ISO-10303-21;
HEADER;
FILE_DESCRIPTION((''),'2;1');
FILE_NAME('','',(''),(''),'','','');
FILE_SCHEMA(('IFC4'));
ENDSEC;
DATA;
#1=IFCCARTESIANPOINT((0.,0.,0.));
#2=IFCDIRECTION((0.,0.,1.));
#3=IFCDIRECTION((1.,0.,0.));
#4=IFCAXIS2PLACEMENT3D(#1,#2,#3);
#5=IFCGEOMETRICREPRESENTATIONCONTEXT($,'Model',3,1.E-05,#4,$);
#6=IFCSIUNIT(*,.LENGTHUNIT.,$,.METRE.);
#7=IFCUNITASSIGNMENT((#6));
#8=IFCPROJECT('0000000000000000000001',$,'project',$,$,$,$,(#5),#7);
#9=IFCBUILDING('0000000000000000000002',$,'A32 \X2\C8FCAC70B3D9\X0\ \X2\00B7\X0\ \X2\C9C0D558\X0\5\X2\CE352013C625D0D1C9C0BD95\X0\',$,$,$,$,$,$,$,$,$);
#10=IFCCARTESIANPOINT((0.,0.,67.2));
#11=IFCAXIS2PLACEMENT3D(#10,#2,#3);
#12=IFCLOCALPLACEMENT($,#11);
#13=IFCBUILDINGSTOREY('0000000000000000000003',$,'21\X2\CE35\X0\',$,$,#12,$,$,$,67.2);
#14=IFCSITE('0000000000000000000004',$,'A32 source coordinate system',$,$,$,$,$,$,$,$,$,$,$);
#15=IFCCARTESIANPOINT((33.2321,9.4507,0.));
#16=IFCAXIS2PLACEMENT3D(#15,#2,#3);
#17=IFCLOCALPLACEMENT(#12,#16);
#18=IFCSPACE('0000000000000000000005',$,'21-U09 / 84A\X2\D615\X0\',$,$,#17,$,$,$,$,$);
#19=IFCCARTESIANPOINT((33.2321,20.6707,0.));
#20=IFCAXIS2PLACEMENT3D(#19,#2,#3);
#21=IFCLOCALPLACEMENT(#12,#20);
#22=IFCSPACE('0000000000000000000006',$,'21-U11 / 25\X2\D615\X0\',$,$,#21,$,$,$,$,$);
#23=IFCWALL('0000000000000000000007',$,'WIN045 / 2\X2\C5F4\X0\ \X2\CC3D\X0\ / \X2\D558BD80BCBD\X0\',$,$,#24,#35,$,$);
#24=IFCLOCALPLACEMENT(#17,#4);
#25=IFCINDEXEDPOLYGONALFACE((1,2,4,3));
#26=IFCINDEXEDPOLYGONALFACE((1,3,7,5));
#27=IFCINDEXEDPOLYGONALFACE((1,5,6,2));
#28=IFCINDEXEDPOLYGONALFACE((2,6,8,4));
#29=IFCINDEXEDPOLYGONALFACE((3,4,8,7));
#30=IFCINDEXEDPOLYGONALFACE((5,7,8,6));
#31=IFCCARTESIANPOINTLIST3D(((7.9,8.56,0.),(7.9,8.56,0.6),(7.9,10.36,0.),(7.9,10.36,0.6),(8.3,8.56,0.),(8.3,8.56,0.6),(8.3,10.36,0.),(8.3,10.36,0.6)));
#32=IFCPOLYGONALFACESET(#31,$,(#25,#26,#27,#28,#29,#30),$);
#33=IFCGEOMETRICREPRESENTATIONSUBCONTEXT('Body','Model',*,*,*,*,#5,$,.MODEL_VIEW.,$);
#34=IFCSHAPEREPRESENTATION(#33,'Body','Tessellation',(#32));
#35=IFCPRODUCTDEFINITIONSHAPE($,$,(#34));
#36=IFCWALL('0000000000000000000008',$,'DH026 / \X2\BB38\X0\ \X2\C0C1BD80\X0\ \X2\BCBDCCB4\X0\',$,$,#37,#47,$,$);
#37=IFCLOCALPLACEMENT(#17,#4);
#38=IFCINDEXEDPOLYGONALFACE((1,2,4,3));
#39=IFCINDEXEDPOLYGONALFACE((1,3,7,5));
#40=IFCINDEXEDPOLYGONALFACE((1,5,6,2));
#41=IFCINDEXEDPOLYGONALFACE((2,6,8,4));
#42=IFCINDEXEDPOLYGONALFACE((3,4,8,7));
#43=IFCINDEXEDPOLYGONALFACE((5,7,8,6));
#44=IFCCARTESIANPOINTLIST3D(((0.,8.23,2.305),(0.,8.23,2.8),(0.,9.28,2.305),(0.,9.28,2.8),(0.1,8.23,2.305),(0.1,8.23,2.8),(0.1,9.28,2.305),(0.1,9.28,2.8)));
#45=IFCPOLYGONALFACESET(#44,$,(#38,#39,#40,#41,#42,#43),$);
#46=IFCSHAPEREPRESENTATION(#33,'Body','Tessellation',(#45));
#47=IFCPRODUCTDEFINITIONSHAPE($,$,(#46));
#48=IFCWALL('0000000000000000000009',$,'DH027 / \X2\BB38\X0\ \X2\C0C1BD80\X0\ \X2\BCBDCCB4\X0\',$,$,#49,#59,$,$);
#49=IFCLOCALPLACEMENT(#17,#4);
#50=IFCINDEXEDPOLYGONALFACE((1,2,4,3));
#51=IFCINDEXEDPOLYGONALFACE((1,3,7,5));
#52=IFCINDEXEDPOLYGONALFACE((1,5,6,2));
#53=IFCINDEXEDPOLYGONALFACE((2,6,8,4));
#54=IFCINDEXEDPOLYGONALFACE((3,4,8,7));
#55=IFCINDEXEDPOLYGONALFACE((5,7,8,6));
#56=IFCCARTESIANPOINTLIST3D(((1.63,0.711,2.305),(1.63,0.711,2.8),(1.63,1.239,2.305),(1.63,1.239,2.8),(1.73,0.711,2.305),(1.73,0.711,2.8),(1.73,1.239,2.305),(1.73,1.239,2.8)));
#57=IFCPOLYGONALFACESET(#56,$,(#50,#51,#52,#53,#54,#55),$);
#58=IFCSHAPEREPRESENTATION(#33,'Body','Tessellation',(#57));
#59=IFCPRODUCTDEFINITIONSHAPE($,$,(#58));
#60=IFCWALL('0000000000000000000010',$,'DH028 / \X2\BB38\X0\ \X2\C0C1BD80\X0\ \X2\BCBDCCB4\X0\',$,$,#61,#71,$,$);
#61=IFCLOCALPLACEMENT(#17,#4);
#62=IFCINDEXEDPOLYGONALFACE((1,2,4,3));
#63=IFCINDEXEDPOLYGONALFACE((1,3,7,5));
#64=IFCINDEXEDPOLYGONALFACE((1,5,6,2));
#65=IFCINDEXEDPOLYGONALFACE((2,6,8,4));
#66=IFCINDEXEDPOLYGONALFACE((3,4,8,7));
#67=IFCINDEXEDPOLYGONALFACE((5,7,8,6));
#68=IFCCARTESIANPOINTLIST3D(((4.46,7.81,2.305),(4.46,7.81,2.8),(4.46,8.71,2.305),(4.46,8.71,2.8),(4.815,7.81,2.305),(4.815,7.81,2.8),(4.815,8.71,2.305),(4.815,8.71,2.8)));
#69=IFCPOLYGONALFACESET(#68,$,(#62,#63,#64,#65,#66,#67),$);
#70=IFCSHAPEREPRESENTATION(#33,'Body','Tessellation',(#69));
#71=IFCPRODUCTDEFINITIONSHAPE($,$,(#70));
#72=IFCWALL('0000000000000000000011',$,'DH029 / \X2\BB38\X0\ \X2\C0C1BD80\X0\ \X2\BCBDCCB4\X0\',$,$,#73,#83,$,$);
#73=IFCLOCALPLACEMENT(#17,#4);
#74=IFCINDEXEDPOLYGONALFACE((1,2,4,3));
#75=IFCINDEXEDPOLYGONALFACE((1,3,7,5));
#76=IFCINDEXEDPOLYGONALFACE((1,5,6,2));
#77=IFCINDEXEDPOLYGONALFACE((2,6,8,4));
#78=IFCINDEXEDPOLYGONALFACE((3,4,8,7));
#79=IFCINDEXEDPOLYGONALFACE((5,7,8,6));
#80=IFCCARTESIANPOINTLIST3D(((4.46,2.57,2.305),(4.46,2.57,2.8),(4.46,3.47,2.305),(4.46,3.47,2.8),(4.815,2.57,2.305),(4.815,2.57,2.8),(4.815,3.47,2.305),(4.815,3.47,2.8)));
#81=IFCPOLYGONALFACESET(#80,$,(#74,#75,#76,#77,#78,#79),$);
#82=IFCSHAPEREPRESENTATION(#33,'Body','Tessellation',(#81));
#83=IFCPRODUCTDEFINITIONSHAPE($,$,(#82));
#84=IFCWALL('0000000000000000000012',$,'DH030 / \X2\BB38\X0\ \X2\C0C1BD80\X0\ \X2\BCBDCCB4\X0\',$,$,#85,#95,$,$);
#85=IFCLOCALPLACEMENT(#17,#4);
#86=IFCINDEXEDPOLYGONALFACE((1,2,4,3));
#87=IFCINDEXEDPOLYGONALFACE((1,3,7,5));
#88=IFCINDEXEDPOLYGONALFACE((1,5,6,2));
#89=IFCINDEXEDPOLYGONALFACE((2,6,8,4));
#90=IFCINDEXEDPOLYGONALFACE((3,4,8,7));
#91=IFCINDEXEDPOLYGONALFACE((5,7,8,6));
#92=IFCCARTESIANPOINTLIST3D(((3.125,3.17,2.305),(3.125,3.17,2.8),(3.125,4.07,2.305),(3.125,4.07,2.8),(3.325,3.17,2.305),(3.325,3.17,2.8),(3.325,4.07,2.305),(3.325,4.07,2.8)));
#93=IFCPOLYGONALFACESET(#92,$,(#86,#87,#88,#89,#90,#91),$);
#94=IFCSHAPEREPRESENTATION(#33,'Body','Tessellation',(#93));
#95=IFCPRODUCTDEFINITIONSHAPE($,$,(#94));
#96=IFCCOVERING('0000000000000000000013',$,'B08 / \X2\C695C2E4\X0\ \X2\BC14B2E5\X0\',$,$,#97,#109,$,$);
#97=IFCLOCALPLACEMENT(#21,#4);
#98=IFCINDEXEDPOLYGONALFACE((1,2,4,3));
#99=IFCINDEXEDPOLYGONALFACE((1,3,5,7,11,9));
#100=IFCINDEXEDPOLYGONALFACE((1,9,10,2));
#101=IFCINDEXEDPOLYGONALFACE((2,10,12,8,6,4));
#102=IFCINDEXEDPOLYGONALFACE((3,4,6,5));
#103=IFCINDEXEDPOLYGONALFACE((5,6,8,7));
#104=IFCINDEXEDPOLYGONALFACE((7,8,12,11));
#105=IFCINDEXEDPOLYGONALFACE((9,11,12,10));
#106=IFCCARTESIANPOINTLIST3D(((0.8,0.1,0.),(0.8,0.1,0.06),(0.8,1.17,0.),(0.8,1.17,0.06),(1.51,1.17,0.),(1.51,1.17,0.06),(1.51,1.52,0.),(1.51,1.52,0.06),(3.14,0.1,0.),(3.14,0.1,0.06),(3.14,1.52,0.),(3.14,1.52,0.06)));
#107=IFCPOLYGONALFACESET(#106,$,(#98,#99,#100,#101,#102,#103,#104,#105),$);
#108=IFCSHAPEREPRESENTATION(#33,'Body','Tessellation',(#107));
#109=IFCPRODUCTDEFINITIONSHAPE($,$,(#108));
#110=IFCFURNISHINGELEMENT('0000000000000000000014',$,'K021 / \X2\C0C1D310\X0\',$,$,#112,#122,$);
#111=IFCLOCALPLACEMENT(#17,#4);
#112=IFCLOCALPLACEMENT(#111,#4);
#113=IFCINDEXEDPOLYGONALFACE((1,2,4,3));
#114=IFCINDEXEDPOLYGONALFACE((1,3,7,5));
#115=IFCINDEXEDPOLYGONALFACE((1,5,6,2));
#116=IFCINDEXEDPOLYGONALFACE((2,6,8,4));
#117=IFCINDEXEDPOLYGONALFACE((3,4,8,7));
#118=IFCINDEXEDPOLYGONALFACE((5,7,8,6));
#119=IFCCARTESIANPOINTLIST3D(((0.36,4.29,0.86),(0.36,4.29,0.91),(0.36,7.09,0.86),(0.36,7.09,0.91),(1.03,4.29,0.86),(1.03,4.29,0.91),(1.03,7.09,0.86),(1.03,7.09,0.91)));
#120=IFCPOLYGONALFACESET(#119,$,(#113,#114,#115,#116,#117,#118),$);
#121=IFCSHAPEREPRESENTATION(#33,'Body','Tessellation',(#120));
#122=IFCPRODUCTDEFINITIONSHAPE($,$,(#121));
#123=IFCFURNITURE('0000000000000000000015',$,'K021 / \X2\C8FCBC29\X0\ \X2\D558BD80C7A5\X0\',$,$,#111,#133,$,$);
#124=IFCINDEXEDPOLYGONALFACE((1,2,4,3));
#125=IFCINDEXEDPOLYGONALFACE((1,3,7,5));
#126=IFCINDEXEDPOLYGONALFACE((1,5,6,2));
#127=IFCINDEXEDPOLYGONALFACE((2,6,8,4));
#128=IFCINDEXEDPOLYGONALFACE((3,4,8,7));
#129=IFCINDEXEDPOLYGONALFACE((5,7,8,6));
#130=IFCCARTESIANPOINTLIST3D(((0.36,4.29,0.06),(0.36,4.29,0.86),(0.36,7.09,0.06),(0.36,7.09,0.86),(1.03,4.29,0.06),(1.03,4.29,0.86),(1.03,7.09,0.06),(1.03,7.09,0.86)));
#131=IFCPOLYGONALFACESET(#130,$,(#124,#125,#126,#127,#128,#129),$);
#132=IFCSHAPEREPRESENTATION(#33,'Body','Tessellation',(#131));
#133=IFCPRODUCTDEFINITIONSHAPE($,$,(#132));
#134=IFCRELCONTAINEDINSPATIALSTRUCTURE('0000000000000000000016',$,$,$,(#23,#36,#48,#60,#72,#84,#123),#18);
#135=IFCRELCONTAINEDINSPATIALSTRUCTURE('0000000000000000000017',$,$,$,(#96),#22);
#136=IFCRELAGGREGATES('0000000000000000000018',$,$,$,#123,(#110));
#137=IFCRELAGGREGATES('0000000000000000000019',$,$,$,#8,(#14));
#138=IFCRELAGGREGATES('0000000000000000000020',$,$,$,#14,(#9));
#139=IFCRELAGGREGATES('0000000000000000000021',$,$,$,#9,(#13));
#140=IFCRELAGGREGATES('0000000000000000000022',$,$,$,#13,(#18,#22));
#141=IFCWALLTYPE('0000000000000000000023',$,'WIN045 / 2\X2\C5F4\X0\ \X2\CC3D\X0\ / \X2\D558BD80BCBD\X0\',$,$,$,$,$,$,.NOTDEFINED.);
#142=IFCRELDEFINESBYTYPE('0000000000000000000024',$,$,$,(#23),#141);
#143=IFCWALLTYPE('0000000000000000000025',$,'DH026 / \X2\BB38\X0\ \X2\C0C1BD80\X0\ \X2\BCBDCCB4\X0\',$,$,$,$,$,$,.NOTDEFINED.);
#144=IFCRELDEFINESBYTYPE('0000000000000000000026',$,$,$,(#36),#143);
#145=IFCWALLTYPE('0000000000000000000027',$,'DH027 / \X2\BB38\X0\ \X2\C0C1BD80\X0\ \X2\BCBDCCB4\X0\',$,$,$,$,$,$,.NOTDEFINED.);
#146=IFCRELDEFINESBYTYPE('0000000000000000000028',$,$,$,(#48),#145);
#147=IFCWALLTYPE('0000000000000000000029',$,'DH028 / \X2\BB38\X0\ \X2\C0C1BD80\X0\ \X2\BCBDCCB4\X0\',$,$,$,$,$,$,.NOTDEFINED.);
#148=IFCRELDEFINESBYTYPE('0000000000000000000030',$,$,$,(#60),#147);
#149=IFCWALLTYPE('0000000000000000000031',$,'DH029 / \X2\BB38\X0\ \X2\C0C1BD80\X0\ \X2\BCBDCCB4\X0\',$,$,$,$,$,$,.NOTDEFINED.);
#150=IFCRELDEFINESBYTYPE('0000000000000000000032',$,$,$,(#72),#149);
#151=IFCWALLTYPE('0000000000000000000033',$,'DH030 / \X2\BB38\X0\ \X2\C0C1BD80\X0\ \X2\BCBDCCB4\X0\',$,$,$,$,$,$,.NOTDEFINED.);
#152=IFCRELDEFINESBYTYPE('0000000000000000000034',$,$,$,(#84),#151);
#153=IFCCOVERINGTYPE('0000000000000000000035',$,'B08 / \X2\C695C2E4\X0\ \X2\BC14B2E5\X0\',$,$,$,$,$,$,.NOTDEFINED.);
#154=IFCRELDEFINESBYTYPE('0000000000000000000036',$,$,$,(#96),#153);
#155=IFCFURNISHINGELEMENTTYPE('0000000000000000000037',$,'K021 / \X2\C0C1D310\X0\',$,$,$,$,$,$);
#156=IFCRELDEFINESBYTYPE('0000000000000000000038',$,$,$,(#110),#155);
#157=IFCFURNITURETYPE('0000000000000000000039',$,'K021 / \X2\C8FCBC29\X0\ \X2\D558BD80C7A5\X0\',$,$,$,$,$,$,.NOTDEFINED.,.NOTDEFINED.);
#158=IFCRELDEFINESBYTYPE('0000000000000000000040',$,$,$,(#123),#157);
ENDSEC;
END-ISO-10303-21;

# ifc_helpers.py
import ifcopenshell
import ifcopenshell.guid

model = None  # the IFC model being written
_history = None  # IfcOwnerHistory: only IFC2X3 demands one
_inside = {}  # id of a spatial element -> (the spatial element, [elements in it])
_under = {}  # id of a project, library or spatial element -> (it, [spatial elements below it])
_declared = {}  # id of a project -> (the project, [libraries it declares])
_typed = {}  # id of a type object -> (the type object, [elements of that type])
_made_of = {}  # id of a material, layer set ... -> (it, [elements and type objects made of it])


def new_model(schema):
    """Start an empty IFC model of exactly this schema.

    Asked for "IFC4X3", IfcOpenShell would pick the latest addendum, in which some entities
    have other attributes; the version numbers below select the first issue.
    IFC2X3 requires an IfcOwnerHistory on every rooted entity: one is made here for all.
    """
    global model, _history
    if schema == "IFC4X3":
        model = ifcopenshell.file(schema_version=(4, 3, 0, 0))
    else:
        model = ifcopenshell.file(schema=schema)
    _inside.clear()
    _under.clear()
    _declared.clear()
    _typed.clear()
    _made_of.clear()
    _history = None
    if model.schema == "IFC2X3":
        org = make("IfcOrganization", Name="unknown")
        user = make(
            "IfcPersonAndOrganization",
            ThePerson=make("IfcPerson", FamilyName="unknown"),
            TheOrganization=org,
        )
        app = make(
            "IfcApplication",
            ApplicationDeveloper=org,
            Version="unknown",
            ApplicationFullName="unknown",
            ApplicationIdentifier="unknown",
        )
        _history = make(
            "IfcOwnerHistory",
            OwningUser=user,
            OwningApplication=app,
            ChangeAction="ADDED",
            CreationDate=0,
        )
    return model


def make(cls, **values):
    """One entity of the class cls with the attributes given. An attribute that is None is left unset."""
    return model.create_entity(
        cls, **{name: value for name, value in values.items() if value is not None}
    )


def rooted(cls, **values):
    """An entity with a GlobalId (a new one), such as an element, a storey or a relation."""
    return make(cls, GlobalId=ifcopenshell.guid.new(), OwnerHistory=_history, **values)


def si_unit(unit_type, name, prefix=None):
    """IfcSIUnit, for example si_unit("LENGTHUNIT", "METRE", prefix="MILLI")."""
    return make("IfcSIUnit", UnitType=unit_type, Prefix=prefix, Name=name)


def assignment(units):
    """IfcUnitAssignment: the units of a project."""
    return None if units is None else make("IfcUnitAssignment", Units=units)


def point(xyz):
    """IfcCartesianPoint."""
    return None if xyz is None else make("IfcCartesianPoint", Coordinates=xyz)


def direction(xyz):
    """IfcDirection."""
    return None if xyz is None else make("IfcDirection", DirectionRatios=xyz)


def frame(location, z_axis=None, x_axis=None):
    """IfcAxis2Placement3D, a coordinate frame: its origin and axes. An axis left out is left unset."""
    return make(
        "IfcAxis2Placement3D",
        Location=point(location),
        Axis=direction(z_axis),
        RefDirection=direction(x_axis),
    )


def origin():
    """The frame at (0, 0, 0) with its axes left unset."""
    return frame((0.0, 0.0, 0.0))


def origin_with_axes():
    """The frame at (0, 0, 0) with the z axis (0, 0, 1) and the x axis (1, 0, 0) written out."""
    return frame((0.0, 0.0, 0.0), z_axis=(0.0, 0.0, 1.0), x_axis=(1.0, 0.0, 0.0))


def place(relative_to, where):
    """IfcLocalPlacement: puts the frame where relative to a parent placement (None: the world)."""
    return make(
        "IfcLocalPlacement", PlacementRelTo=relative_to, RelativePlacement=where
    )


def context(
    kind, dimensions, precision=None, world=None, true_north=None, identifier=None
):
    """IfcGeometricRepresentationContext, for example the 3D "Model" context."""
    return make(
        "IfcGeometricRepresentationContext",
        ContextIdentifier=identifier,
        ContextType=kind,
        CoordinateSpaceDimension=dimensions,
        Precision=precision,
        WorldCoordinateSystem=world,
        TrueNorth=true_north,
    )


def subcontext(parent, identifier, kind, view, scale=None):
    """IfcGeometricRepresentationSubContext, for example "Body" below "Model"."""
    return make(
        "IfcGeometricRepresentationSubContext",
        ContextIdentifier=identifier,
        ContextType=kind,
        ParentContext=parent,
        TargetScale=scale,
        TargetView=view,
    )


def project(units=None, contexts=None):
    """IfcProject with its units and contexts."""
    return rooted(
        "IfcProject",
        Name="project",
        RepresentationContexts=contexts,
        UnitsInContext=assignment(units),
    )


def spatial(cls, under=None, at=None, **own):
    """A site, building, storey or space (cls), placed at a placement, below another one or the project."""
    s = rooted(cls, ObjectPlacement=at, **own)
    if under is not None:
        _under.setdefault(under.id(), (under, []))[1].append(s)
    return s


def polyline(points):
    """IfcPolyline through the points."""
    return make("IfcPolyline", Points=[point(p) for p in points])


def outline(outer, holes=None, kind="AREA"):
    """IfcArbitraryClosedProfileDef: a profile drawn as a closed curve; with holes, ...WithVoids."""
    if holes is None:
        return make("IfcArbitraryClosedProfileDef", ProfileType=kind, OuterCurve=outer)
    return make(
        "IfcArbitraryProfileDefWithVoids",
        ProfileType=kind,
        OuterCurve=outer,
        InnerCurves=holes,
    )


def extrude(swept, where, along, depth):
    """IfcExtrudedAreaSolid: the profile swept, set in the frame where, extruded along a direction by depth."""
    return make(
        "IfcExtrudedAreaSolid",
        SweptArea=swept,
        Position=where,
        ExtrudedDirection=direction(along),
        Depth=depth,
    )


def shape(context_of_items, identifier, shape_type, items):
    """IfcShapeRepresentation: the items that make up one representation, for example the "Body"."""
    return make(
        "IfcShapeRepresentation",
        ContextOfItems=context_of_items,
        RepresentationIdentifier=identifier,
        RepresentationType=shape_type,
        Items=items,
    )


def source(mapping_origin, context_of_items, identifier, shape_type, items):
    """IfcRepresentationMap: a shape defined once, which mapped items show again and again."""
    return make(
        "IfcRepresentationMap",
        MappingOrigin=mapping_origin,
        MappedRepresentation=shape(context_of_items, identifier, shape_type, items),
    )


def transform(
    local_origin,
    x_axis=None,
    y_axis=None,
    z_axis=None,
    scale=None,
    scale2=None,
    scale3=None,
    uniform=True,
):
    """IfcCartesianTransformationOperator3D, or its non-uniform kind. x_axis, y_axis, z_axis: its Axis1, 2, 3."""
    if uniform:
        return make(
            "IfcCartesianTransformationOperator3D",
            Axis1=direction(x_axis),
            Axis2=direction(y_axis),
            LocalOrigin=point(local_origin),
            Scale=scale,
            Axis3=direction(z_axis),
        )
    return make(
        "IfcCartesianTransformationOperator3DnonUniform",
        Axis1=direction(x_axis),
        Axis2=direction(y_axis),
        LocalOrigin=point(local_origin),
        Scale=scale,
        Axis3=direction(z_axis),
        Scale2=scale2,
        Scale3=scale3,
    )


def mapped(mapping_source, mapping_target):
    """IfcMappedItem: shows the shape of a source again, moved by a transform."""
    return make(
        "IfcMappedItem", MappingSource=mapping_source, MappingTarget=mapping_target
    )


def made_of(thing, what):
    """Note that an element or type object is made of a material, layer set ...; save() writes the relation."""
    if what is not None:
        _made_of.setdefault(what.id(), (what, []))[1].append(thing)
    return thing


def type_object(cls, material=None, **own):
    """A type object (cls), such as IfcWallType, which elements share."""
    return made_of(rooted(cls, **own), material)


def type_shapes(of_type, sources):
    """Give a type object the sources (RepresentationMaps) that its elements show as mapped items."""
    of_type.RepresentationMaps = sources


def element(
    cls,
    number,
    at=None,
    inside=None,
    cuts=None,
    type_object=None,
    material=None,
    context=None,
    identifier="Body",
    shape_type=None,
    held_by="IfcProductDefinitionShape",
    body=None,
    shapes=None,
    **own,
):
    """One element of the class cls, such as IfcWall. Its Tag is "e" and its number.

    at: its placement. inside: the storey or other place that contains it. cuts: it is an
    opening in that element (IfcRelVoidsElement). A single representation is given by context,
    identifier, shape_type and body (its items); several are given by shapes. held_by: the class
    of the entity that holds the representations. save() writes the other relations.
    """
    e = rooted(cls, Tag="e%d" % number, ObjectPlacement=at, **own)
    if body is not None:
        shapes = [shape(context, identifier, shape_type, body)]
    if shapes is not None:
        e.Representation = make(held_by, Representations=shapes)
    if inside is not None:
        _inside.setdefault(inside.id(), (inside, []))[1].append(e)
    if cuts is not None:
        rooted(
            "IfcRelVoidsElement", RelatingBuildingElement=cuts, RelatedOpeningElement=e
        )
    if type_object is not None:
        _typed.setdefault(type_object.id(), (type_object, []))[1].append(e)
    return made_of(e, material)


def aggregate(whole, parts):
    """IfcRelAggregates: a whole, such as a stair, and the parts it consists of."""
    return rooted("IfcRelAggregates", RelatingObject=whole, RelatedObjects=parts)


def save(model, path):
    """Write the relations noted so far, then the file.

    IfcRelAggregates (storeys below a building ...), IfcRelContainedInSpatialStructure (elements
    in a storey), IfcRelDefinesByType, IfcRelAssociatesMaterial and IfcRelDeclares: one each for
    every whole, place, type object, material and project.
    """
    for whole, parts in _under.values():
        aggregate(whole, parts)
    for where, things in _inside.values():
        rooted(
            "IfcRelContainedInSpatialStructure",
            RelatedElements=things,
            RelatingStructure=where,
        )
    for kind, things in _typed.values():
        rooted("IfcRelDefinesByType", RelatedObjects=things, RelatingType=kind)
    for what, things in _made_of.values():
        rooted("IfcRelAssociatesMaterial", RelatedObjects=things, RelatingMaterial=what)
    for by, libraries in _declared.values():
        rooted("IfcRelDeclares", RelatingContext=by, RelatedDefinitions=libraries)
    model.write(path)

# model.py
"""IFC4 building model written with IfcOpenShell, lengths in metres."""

from ifc_helpers import new_model, si_unit, frame, origin, origin_with_axes, place, context, subcontext, project, spatial, polyline, outline, extrude, source, transform, mapped, type_object, type_shapes, element, aggregate, save


model = new_model("IFC4")

# Units and contexts
model_context = context("Model", 3, precision=1e-05, world=origin_with_axes())
body_context = subcontext(model_context, "Body", "Model", "MODEL_VIEW")
ifc_project = project(units=[si_unit("LENGTHUNIT", "METRE")], contexts=[model_context])

# Site, building, storey, space
site = spatial("IfcSite", under=ifc_project, Name="A32 source coordinate system")
building = spatial("IfcBuilding", under=site, Name="A32 주거동 · 지하5층–옥탑지붕")
storey_placement = place(None, frame((0.0, 0.0, 67.2), z_axis=(0.0, 0.0, 1.0), x_axis=(1.0, 0.0, 0.0)))
storey = spatial("IfcBuildingStorey", under=building, at=storey_placement, Name="21층", Elevation=67.2)
space_1_placement = place(storey_placement, frame((33.2321, 9.4507, 0.0), z_axis=(0.0, 0.0, 1.0), x_axis=(1.0, 0.0, 0.0)))
space_1 = spatial("IfcSpace", under=storey, at=space_1_placement, Name="21-U09 / 84A형")

# Walls
wall_type_1 = type_object("IfcWallType", Name="WIN045 / 2열 창 / 하부벽", PredefinedType="NOTDEFINED")
shared_shape_1 = source(origin(), body_context, "Body", "SweptSolid", [
    extrude(outline(polyline([(7.9, 10.36), (8.3, 10.36), (8.3, 8.56), (7.9, 8.56), (7.9, 10.36)])), origin(), (0.0, 0.0, 1.0), 0.6),
])
type_shapes(wall_type_1, [shared_shape_1])
wall_1_placement = place(space_1_placement, origin_with_axes())
element("IfcWall", 1, at=wall_1_placement, inside=space_1, type_object=wall_type_1, Name="WIN045 / 2열 창 / 하부벽", context=body_context, shape_type="MappedRepresentation", body=[
    mapped(shared_shape_1, transform((0.0, 0.0, 0.0), scale=1.0)),
])
wall_type_2 = type_object("IfcWallType", Name="DH026 / 문 상부 벽체", PredefinedType="NOTDEFINED")
shared_shape_2 = source(origin(), body_context, "Body", "SweptSolid", [
    extrude(outline(polyline([(0.1, 9.28), (0.1, 8.23), (0.0, 8.23), (0.0, 9.28), (0.1, 9.28)])), frame((0.0, 0.0, 2.305)), (0.0, 0.0, 1.0), 0.495),
])
type_shapes(wall_type_2, [shared_shape_2])
wall_2_placement = place(space_1_placement, origin_with_axes())
element("IfcWall", 2, at=wall_2_placement, inside=space_1, type_object=wall_type_2, Name="DH026 / 문 상부 벽체", context=body_context, shape_type="MappedRepresentation", body=[
    mapped(shared_shape_2, transform((0.0, 0.0, 0.0), scale=1.0)),
])
wall_type_3 = type_object("IfcWallType", Name="DH027 / 문 상부 벽체", PredefinedType="NOTDEFINED")
shared_shape_3 = source(origin(), body_context, "Body", "SweptSolid", [
    extrude(outline(polyline([(1.63, 1.239), (1.73, 1.239), (1.73, 0.711), (1.63, 0.711), (1.63, 1.239)])), frame((0.0, 0.0, 2.305)), (0.0, 0.0, 1.0), 0.495),
])
type_shapes(wall_type_3, [shared_shape_3])
wall_3_placement = place(space_1_placement, origin_with_axes())
element("IfcWall", 3, at=wall_3_placement, inside=space_1, type_object=wall_type_3, Name="DH027 / 문 상부 벽체", context=body_context, shape_type="MappedRepresentation", body=[
    mapped(shared_shape_3, transform((0.0, 0.0, 0.0), scale=1.0)),
])
wall_type_4 = type_object("IfcWallType", Name="DH028 / 문 상부 벽체", PredefinedType="NOTDEFINED")
shared_shape_4 = source(origin(), body_context, "Body", "SweptSolid", [
    extrude(outline(polyline([(4.815, 8.71), (4.815, 7.81), (4.46, 7.81), (4.46, 8.71), (4.815, 8.71)])), frame((0.0, 0.0, 2.305)), (0.0, 0.0, 1.0), 0.495),
])
type_shapes(wall_type_4, [shared_shape_4])
wall_4_placement = place(space_1_placement, origin_with_axes())
element("IfcWall", 4, at=wall_4_placement, inside=space_1, type_object=wall_type_4, Name="DH028 / 문 상부 벽체", context=body_context, shape_type="MappedRepresentation", body=[
    mapped(shared_shape_4, transform((0.0, 0.0, 0.0), scale=1.0)),
])
wall_type_5 = type_object("IfcWallType", Name="DH029 / 문 상부 벽체", PredefinedType="NOTDEFINED")
shared_shape_5 = source(origin(), body_context, "Body", "SweptSolid", [
    extrude(outline(polyline([(4.815, 3.47), (4.815, 2.57), (4.46, 2.57), (4.46, 3.47), (4.815, 3.47)])), frame((0.0, 0.0, 2.305)), (0.0, 0.0, 1.0), 0.495),
])
type_shapes(wall_type_5, [shared_shape_5])
wall_5_placement = place(space_1_placement, origin_with_axes())
element("IfcWall", 5, at=wall_5_placement, inside=space_1, type_object=wall_type_5, Name="DH029 / 문 상부 벽체", context=body_context, shape_type="MappedRepresentation", body=[
    mapped(shared_shape_5, transform((0.0, 0.0, 0.0), scale=1.0)),
])
wall_type_6 = type_object("IfcWallType", Name="DH030 / 문 상부 벽체", PredefinedType="NOTDEFINED")
shared_shape_6 = source(origin(), body_context, "Body", "SweptSolid", [
    extrude(outline(polyline([(3.325, 4.07), (3.325, 3.17), (3.125, 3.17), (3.125, 4.07), (3.325, 4.07)])), frame((0.0, 0.0, 2.305)), (0.0, 0.0, 1.0), 0.495),
])
type_shapes(wall_type_6, [shared_shape_6])
wall_6_placement = place(space_1_placement, origin_with_axes())
element("IfcWall", 6, at=wall_6_placement, inside=space_1, type_object=wall_type_6, Name="DH030 / 문 상부 벽체", context=body_context, shape_type="MappedRepresentation", body=[
    mapped(shared_shape_6, transform((0.0, 0.0, 0.0), scale=1.0)),
])

# Shared definitions
space_2_placement = place(storey_placement, frame((33.2321, 20.6707, 0.0), z_axis=(0.0, 0.0, 1.0), x_axis=(1.0, 0.0, 0.0)))
space_2 = spatial("IfcSpace", under=storey, at=space_2_placement, Name="21-U11 / 25형")

# Covering
covering_type_1 = type_object("IfcCoveringType", Name="B08 / 욕실 바닥", PredefinedType="NOTDEFINED")
shared_shape_7 = source(origin(), body_context, "Body", "SweptSolid", [
    extrude(outline(polyline([(3.14, 0.1), (0.8, 0.1), (0.8, 1.17), (1.51, 1.17), (1.51, 1.52), (3.14, 1.52), (3.14, 0.1)])), origin(), (0.0, 0.0, 1.0), 0.06),
])
type_shapes(covering_type_1, [shared_shape_7])
covering_1_placement = place(space_2_placement, origin_with_axes())
element("IfcCovering", 7, at=covering_1_placement, inside=space_2, type_object=covering_type_1, Name="B08 / 욕실 바닥", context=body_context, shape_type="MappedRepresentation", body=[
    mapped(shared_shape_7, transform((0.0, 0.0, 0.0), scale=1.0)),
])

# Furnishing element
furnishing_element_type = type_object("IfcFurnishingElementType", Name="K021 / 상판")
shared_shape_8 = source(origin(), body_context, "Body", "SweptSolid", [
    extrude(outline(polyline([(0.36, 7.09), (1.03, 7.09), (1.03, 4.29), (0.36, 4.29), (0.36, 7.09)])), frame((0.0, 0.0, 0.86)), (0.0, 0.0, 1.0), 0.05),
])
type_shapes(furnishing_element_type, [shared_shape_8])
furniture_placement = place(space_1_placement, origin_with_axes())
furnishing_placement = place(furniture_placement, origin_with_axes())
furnishing = element("IfcFurnishingElement", 8, at=furnishing_placement, type_object=furnishing_element_type, Name="K021 / 상판", context=body_context, shape_type="MappedRepresentation", body=[
    mapped(shared_shape_8, transform((0.0, 0.0, 0.0), scale=1.0)),
])

# Furniture
furniture_type = type_object("IfcFurnitureType", Name="K021 / 주방 하부장", AssemblyPlace="NOTDEFINED", PredefinedType="NOTDEFINED")
shared_shape_9 = source(origin(), body_context, "Body", "SweptSolid", [
    extrude(outline(polyline([(0.36, 4.29), (0.36, 7.09), (1.03, 7.09), (1.03, 4.29), (0.36, 4.29)])), frame((0.0, 0.0, 0.06)), (0.0, 0.0, 1.0), 0.8),
])
type_shapes(furniture_type, [shared_shape_9])
furniture = element("IfcFurniture", 9, at=furniture_placement, inside=space_1, type_object=furniture_type, Name="K021 / 주방 하부장", context=body_context, shape_type="MappedRepresentation", body=[
    mapped(shared_shape_9, transform((0.0, 0.0, 0.0), scale=1.0)),
])
aggregate(furniture, [furnishing])

save(model, "model.ifc")
